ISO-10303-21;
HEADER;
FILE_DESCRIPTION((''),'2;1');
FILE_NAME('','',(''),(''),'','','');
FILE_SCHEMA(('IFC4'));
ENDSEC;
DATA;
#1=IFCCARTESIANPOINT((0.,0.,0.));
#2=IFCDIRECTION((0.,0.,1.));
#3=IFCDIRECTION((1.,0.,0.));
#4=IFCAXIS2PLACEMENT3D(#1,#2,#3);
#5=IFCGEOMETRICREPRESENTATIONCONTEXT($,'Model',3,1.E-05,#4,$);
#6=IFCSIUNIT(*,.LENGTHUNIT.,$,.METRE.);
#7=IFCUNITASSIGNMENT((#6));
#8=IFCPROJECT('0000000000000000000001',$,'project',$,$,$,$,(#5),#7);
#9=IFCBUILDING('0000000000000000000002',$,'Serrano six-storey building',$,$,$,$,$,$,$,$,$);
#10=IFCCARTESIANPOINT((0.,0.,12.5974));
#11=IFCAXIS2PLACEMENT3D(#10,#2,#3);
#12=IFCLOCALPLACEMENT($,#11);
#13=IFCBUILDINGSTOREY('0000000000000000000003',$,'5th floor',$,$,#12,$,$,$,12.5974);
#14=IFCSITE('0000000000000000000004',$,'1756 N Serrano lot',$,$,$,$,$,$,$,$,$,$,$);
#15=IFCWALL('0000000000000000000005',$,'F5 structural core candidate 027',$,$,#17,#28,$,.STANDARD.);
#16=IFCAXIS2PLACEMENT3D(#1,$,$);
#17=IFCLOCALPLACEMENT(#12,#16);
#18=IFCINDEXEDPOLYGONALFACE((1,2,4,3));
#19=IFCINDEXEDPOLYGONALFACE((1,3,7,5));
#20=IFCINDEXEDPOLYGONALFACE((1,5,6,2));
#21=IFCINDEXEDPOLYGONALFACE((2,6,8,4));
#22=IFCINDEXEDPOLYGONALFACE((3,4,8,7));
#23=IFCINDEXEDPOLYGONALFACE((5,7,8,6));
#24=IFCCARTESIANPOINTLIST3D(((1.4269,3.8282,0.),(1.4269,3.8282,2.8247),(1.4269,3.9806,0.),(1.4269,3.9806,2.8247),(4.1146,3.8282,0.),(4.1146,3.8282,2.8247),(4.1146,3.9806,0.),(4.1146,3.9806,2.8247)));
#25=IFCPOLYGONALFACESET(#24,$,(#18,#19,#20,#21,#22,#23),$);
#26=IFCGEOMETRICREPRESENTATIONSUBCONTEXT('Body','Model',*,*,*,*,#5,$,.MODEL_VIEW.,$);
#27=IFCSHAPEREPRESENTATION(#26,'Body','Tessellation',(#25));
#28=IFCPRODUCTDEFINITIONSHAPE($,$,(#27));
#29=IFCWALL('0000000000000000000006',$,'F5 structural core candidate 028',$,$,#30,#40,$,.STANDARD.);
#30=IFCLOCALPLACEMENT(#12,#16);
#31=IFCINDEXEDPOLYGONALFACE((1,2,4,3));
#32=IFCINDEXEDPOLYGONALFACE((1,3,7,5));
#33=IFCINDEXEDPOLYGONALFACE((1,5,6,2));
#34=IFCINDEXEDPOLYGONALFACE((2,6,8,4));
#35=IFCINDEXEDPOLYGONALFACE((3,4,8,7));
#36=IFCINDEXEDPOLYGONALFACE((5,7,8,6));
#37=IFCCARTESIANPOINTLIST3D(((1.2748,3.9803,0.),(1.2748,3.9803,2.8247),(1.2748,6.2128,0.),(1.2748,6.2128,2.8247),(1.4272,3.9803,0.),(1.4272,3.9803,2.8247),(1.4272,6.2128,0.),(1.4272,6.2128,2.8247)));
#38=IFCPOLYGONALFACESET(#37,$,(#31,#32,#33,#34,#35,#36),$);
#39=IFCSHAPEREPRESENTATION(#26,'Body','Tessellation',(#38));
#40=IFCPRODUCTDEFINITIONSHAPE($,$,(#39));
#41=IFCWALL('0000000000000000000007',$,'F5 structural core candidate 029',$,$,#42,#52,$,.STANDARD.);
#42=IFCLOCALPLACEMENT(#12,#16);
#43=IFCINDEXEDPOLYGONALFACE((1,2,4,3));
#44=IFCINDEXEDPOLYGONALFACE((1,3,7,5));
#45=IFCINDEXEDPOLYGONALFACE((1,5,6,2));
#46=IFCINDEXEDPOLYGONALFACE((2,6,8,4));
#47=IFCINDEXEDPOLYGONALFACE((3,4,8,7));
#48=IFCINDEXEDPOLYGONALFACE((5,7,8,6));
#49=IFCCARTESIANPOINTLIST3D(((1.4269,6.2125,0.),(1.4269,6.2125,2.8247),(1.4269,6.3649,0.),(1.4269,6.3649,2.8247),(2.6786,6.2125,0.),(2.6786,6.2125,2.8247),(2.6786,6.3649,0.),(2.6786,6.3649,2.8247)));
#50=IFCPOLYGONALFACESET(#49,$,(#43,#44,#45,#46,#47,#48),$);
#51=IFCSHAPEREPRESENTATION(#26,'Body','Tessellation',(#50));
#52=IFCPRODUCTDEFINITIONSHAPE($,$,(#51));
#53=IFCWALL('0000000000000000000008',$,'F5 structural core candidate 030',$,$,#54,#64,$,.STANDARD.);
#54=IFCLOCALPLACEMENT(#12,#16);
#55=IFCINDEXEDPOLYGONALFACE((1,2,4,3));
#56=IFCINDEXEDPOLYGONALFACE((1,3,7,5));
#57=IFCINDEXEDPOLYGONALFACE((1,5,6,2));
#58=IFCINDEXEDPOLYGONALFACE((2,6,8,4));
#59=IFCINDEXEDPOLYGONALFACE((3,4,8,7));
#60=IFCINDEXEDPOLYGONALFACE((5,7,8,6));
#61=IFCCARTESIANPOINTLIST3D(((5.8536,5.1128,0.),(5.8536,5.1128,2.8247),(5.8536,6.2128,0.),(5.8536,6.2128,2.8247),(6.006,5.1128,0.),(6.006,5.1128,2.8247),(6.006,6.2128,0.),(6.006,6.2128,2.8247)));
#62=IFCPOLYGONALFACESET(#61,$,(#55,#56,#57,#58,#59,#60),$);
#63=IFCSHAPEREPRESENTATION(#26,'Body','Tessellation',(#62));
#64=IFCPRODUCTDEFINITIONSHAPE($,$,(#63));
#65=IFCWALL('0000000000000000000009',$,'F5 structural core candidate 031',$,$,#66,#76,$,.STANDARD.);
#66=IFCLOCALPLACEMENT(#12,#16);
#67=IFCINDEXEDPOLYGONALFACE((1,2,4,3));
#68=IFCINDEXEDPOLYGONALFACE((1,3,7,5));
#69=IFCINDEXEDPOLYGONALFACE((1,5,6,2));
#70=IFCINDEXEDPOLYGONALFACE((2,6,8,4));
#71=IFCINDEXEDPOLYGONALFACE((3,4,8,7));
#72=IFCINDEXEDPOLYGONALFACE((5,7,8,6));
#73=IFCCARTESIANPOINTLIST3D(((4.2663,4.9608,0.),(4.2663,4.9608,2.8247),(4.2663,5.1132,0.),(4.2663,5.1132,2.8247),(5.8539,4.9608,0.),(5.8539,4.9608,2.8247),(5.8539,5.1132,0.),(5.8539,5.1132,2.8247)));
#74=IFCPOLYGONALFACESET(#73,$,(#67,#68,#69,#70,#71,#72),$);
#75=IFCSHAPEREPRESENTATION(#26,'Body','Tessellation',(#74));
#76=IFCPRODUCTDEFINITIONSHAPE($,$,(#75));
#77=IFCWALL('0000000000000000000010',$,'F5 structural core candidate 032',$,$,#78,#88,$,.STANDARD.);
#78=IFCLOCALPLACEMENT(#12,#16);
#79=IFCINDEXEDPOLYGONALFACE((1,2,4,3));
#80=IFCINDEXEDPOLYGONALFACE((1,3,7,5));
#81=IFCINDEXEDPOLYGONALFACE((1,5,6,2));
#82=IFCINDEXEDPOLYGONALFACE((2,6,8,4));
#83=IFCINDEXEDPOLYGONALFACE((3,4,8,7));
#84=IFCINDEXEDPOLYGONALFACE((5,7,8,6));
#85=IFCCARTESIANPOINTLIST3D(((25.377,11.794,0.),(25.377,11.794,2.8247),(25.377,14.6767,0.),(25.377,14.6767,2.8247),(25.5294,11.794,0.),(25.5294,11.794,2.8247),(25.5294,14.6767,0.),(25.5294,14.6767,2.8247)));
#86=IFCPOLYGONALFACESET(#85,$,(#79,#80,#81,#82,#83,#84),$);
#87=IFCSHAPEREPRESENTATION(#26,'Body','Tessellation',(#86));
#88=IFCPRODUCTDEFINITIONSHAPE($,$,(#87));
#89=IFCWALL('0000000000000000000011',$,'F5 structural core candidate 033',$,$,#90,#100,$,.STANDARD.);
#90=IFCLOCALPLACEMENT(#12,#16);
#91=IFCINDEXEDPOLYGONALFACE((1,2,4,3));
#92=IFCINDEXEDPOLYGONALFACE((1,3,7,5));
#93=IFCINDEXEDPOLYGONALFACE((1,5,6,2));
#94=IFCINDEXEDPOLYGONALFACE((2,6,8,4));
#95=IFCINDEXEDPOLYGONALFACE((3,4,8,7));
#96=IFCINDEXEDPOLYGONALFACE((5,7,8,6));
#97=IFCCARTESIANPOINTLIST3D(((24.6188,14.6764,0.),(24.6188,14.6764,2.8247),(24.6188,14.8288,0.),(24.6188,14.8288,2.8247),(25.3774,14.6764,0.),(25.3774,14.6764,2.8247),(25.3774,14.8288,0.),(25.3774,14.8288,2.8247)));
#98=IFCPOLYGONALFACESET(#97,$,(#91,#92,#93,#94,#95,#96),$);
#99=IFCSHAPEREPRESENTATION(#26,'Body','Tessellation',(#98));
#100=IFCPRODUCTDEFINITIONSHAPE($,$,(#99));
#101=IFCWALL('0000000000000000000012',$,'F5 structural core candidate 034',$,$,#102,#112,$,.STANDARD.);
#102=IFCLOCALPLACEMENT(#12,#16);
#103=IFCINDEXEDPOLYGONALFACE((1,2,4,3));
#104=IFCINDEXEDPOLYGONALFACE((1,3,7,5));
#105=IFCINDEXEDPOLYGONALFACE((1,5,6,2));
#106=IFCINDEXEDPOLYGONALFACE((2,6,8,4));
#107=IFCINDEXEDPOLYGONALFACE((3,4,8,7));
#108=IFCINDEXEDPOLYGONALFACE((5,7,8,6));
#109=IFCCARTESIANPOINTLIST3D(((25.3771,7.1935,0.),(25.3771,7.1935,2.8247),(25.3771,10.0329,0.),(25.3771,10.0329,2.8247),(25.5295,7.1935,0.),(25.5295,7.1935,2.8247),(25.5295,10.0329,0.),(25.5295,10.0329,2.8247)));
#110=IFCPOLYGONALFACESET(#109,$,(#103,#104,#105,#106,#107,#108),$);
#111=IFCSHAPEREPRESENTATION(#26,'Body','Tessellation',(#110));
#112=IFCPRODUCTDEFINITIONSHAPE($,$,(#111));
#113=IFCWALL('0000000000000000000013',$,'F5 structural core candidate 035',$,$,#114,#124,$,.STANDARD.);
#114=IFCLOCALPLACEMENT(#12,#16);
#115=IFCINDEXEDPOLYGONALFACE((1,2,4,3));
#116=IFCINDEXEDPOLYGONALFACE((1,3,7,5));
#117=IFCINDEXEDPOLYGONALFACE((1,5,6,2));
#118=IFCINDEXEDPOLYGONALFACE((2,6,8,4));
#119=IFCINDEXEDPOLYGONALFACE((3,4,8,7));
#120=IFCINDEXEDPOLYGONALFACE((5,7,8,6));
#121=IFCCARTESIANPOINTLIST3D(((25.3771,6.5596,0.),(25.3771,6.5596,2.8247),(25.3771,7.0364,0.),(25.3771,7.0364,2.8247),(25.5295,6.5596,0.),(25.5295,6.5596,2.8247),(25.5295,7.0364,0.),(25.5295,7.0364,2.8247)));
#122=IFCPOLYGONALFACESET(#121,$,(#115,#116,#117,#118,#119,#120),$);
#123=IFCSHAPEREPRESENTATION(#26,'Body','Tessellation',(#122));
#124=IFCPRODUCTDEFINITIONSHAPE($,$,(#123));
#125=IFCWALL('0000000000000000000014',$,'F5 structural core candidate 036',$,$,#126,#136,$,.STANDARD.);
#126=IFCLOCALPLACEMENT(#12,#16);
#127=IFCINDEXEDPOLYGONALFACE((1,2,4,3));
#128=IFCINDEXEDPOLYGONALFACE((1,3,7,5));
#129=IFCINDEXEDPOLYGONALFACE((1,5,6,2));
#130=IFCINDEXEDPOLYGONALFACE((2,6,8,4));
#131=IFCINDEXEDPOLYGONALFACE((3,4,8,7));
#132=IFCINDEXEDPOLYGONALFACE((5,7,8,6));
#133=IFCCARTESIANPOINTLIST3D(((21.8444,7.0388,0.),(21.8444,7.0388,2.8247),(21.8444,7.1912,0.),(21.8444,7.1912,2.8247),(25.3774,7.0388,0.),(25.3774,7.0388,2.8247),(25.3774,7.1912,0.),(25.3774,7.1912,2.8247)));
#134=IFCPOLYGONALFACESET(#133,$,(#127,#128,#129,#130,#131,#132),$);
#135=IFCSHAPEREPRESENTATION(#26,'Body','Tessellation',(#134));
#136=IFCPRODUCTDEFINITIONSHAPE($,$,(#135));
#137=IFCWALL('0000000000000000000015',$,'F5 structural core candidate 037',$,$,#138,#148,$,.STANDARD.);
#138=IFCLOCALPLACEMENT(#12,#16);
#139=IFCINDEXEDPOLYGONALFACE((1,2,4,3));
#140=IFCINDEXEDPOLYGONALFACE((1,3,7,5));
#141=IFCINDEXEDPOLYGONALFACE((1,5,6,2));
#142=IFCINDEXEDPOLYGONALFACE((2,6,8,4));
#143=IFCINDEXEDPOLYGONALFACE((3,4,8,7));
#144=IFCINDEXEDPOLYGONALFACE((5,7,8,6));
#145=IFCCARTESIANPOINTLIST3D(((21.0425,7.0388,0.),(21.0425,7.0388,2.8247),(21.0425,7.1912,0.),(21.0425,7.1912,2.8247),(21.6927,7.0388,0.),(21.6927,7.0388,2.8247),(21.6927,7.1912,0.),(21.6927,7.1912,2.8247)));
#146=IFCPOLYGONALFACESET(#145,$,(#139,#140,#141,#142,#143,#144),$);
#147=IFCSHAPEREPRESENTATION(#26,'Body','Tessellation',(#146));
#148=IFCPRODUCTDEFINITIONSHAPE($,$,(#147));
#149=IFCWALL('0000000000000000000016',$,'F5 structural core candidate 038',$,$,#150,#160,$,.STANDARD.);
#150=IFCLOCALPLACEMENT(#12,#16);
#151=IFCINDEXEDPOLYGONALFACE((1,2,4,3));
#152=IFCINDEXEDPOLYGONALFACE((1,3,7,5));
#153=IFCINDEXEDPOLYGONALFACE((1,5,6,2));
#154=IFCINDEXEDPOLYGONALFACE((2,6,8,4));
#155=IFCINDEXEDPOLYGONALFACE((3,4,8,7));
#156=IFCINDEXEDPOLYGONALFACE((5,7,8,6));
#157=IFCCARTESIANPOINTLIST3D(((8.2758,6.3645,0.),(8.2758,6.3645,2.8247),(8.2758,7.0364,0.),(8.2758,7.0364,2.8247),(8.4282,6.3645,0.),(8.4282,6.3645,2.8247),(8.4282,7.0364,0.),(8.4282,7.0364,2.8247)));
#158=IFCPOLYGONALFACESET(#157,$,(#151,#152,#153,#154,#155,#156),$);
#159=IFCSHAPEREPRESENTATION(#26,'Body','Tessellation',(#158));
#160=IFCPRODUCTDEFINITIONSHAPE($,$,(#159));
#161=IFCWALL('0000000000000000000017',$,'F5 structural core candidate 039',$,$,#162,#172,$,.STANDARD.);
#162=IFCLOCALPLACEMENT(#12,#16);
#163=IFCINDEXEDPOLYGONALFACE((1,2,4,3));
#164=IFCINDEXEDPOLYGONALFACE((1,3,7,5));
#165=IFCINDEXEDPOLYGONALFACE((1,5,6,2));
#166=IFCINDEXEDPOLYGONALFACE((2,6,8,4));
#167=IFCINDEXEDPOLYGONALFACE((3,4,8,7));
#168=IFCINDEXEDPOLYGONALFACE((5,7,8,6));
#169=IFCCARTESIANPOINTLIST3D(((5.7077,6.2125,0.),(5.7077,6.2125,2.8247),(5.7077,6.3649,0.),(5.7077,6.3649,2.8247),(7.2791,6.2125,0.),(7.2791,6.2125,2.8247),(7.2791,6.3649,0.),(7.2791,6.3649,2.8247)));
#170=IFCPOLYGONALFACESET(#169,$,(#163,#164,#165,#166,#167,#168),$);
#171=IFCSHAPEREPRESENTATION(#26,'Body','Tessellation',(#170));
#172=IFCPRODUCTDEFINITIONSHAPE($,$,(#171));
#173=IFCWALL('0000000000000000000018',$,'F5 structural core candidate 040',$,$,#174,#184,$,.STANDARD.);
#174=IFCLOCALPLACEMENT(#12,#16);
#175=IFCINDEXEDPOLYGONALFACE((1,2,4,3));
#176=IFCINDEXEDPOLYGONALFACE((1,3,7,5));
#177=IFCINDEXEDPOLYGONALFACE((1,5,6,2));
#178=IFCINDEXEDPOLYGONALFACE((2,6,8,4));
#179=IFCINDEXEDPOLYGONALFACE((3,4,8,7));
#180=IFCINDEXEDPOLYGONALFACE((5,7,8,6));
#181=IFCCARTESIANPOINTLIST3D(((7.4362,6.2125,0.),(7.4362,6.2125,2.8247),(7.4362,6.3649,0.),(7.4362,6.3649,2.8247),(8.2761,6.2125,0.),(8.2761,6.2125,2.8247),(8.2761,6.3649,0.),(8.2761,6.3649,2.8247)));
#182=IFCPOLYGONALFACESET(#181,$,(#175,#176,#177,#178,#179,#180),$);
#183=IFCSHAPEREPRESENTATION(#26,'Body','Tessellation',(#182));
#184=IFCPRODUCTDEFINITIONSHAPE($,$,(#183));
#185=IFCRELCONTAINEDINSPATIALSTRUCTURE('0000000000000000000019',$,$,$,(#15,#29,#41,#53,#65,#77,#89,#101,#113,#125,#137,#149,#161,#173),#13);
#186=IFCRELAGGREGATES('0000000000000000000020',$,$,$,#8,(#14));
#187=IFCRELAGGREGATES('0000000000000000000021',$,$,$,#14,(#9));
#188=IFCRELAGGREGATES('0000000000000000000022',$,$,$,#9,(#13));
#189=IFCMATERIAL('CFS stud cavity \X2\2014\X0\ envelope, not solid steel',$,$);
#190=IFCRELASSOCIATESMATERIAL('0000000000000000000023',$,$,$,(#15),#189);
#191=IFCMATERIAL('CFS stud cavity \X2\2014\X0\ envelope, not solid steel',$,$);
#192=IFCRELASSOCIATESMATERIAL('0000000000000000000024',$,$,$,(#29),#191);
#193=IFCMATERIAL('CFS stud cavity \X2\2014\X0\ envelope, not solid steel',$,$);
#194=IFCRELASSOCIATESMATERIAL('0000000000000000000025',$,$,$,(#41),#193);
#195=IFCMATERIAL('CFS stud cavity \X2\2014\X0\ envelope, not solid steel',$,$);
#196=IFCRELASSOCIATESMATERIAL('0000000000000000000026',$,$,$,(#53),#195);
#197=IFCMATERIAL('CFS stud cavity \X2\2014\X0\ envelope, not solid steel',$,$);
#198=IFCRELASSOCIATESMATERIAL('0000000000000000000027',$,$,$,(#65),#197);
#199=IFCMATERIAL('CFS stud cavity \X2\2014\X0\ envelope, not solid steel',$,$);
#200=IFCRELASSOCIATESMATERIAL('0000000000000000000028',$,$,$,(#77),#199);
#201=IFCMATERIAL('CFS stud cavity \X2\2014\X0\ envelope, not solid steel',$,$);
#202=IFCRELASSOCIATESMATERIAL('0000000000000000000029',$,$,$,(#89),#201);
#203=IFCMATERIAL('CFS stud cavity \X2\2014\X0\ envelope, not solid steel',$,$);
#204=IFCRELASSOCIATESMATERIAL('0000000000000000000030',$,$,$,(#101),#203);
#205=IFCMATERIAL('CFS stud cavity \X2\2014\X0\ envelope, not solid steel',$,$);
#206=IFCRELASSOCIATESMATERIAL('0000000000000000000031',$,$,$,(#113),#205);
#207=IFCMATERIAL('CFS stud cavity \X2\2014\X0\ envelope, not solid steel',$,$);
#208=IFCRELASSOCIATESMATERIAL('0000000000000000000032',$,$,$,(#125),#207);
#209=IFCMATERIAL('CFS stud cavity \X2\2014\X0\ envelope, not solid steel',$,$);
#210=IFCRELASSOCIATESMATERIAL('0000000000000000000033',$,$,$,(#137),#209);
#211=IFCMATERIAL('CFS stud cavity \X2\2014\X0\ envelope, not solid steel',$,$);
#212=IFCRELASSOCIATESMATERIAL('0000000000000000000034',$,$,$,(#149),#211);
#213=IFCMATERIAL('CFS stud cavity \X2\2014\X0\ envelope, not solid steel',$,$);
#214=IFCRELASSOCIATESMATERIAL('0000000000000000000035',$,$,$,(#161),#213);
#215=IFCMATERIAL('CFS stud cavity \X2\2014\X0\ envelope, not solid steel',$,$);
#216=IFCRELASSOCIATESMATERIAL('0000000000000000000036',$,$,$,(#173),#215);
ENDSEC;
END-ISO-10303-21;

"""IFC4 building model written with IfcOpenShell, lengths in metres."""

from ifc_helpers import new_model, si_unit, frame, origin_with_axes, place, context, subcontext, project, spatial, polyline, outline, extrude, material, element, save


model = new_model("IFC4")

# Units and contexts
model_context = context("Model", 3, precision=1e-05, world=origin_with_axes())
body_context = subcontext(model_context, "Body", "Model", "MODEL_VIEW")
ifc_project = project(units=[si_unit("LENGTHUNIT", "METRE")], contexts=[model_context])

# Site, building, storey
site = spatial("IfcSite", under=ifc_project, Name="1756 N Serrano lot")
building = spatial("IfcBuilding", under=site, Name="Serrano six-storey building")
storey_placement = place(None, frame((0.0, 0.0, 12.5974), z_axis=(0.0, 0.0, 1.0), x_axis=(1.0, 0.0, 0.0)))
storey = spatial("IfcBuildingStorey", under=building, at=storey_placement, Name="5th floor", Elevation=12.5974)

# Walls
ifc_material_1 = material(Name="CFS stud cavity — envelope, not solid steel")
wall_1_placement = place(storey_placement, frame((0.0, 0.0, -12.5974), z_axis=(0.0, 0.0, 1.0), x_axis=(1.0, 0.0, 0.0)))
element("IfcWall", 1, at=wall_1_placement, inside=storey, material=ifc_material_1, Name="F5 structural core candidate 027", PredefinedType="STANDARD", context=body_context, shape_type="SweptSolid", body=[
    extrude(outline(polyline([(4.1146, 3.9806), (4.1146, 3.8282), (1.4269, 3.8282), (1.4269, 3.9806), (4.1146, 3.9806)])), frame((0.0, 0.0, 12.5974)), (0.0, 0.0, 1.0), 2.8247),
])
ifc_material_2 = material(Name="CFS stud cavity — envelope, not solid steel")
wall_2_placement = place(storey_placement, frame((0.0, 0.0, -12.5974), z_axis=(0.0, 0.0, 1.0), x_axis=(1.0, 0.0, 0.0)))
element("IfcWall", 2, at=wall_2_placement, inside=storey, material=ifc_material_2, Name="F5 structural core candidate 028", PredefinedType="STANDARD", context=body_context, shape_type="SweptSolid", body=[
    extrude(outline(polyline([(1.4272, 3.9803), (1.2748, 3.9803), (1.2748, 6.2128), (1.4272, 6.2128), (1.4272, 3.9803)])), frame((0.0, 0.0, 12.5974)), (0.0, 0.0, 1.0), 2.8247),
])
ifc_material_3 = material(Name="CFS stud cavity — envelope, not solid steel")
wall_3_placement = place(storey_placement, frame((0.0, 0.0, -12.5974), z_axis=(0.0, 0.0, 1.0), x_axis=(1.0, 0.0, 0.0)))
element("IfcWall", 3, at=wall_3_placement, inside=storey, material=ifc_material_3, Name="F5 structural core candidate 029", PredefinedType="STANDARD", context=body_context, shape_type="SweptSolid", body=[
    extrude(outline(polyline([(2.6786, 6.3649), (2.6786, 6.2125), (1.4269, 6.2125), (1.4269, 6.3649), (2.6786, 6.3649)])), frame((0.0, 0.0, 12.5974)), (0.0, 0.0, 1.0), 2.8247),
])
ifc_material_4 = material(Name="CFS stud cavity — envelope, not solid steel")
wall_4_placement = place(storey_placement, frame((0.0, 0.0, -12.5974), z_axis=(0.0, 0.0, 1.0), x_axis=(1.0, 0.0, 0.0)))
element("IfcWall", 4, at=wall_4_placement, inside=storey, material=ifc_material_4, Name="F5 structural core candidate 030", PredefinedType="STANDARD", context=body_context, shape_type="SweptSolid", body=[
    extrude(outline(polyline([(6.006, 5.1128), (5.8536, 5.1128), (5.8536, 6.2128), (6.006, 6.2128), (6.006, 5.1128)])), frame((0.0, 0.0, 12.5974)), (0.0, 0.0, 1.0), 2.8247),
])
ifc_material_5 = material(Name="CFS stud cavity — envelope, not solid steel")
wall_5_placement = place(storey_placement, frame((0.0, 0.0, -12.5974), z_axis=(0.0, 0.0, 1.0), x_axis=(1.0, 0.0, 0.0)))
element("IfcWall", 5, at=wall_5_placement, inside=storey, material=ifc_material_5, Name="F5 structural core candidate 031", PredefinedType="STANDARD", context=body_context, shape_type="SweptSolid", body=[
    extrude(outline(polyline([(5.8539, 5.1132), (5.8539, 4.9608), (4.2663, 4.9608), (4.2663, 5.1132), (5.8539, 5.1132)])), frame((0.0, 0.0, 12.5974)), (0.0, 0.0, 1.0), 2.8247),
])
ifc_material_6 = material(Name="CFS stud cavity — envelope, not solid steel")
wall_6_placement = place(storey_placement, frame((0.0, 0.0, -12.5974), z_axis=(0.0, 0.0, 1.0), x_axis=(1.0, 0.0, 0.0)))
element("IfcWall", 6, at=wall_6_placement, inside=storey, material=ifc_material_6, Name="F5 structural core candidate 032", PredefinedType="STANDARD", context=body_context, shape_type="SweptSolid", body=[
    extrude(outline(polyline([(25.5294, 11.794), (25.377, 11.794), (25.377, 14.6767), (25.5294, 14.6767), (25.5294, 11.794)])), frame((0.0, 0.0, 12.5974)), (0.0, 0.0, 1.0), 2.8247),
])
ifc_material_7 = material(Name="CFS stud cavity — envelope, not solid steel")
wall_7_placement = place(storey_placement, frame((0.0, 0.0, -12.5974), z_axis=(0.0, 0.0, 1.0), x_axis=(1.0, 0.0, 0.0)))
element("IfcWall", 7, at=wall_7_placement, inside=storey, material=ifc_material_7, Name="F5 structural core candidate 033", PredefinedType="STANDARD", context=body_context, shape_type="SweptSolid", body=[
    extrude(outline(polyline([(25.3774, 14.8288), (25.3774, 14.6764), (24.6188, 14.6764), (24.6188, 14.8288), (25.3774, 14.8288)])), frame((0.0, 0.0, 12.5974)), (0.0, 0.0, 1.0), 2.8247),
])
ifc_material_8 = material(Name="CFS stud cavity — envelope, not solid steel")
wall_8_placement = place(storey_placement, frame((0.0, 0.0, -12.5974), z_axis=(0.0, 0.0, 1.0), x_axis=(1.0, 0.0, 0.0)))
element("IfcWall", 8, at=wall_8_placement, inside=storey, material=ifc_material_8, Name="F5 structural core candidate 034", PredefinedType="STANDARD", context=body_context, shape_type="SweptSolid", body=[
    extrude(outline(polyline([(25.5295, 7.1935), (25.3771, 7.1935), (25.3771, 10.0329), (25.5295, 10.0329), (25.5295, 7.1935)])), frame((0.0, 0.0, 12.5974)), (0.0, 0.0, 1.0), 2.8247),
])
ifc_material_9 = material(Name="CFS stud cavity — envelope, not solid steel")
wall_9_placement = place(storey_placement, frame((0.0, 0.0, -12.5974), z_axis=(0.0, 0.0, 1.0), x_axis=(1.0, 0.0, 0.0)))
element("IfcWall", 9, at=wall_9_placement, inside=storey, material=ifc_material_9, Name="F5 structural core candidate 035", PredefinedType="STANDARD", context=body_context, shape_type="SweptSolid", body=[
    extrude(outline(polyline([(25.5295, 6.5596), (25.3771, 6.5596), (25.3771, 7.0364), (25.5295, 7.0364), (25.5295, 6.5596)])), frame((0.0, 0.0, 12.5974)), (0.0, 0.0, 1.0), 2.8247),
])
ifc_material_10 = material(Name="CFS stud cavity — envelope, not solid steel")
wall_10_placement = place(storey_placement, frame((0.0, 0.0, -12.5974), z_axis=(0.0, 0.0, 1.0), x_axis=(1.0, 0.0, 0.0)))
element("IfcWall", 10, at=wall_10_placement, inside=storey, material=ifc_material_10, Name="F5 structural core candidate 036", PredefinedType="STANDARD", context=body_context, shape_type="SweptSolid", body=[
    extrude(outline(polyline([(25.3774, 7.1912), (25.3774, 7.0388), (21.8444, 7.0388), (21.8444, 7.1912), (25.3774, 7.1912)])), frame((0.0, 0.0, 12.5974)), (0.0, 0.0, 1.0), 2.8247),
])
ifc_material_11 = material(Name="CFS stud cavity — envelope, not solid steel")
wall_11_placement = place(storey_placement, frame((0.0, 0.0, -12.5974), z_axis=(0.0, 0.0, 1.0), x_axis=(1.0, 0.0, 0.0)))
element("IfcWall", 11, at=wall_11_placement, inside=storey, material=ifc_material_11, Name="F5 structural core candidate 037", PredefinedType="STANDARD", context=body_context, shape_type="SweptSolid", body=[
    extrude(outline(polyline([(21.6927, 7.1912), (21.6927, 7.0388), (21.0425, 7.0388), (21.0425, 7.1912), (21.6927, 7.1912)])), frame((0.0, 0.0, 12.5974)), (0.0, 0.0, 1.0), 2.8247),
])
ifc_material_12 = material(Name="CFS stud cavity — envelope, not solid steel")
wall_12_placement = place(storey_placement, frame((0.0, 0.0, -12.5974), z_axis=(0.0, 0.0, 1.0), x_axis=(1.0, 0.0, 0.0)))
element("IfcWall", 12, at=wall_12_placement, inside=storey, material=ifc_material_12, Name="F5 structural core candidate 038", PredefinedType="STANDARD", context=body_context, shape_type="SweptSolid", body=[
    extrude(outline(polyline([(8.4282, 6.3645), (8.2758, 6.3645), (8.2758, 7.0364), (8.4282, 7.0364), (8.4282, 6.3645)])), frame((0.0, 0.0, 12.5974)), (0.0, 0.0, 1.0), 2.8247),
])
ifc_material_13 = material(Name="CFS stud cavity — envelope, not solid steel")
wall_13_placement = place(storey_placement, frame((0.0, 0.0, -12.5974), z_axis=(0.0, 0.0, 1.0), x_axis=(1.0, 0.0, 0.0)))
element("IfcWall", 13, at=wall_13_placement, inside=storey, material=ifc_material_13, Name="F5 structural core candidate 039", PredefinedType="STANDARD", context=body_context, shape_type="SweptSolid", body=[
    extrude(outline(polyline([(7.2791, 6.3649), (7.2791, 6.2125), (5.7077, 6.2125), (5.7077, 6.3649), (7.2791, 6.3649)])), frame((0.0, 0.0, 12.5974)), (0.0, 0.0, 1.0), 2.8247),
])
ifc_material_14 = material(Name="CFS stud cavity — envelope, not solid steel")
wall_14_placement = place(storey_placement, frame((0.0, 0.0, -12.5974), z_axis=(0.0, 0.0, 1.0), x_axis=(1.0, 0.0, 0.0)))
element("IfcWall", 14, at=wall_14_placement, inside=storey, material=ifc_material_14, Name="F5 structural core candidate 040", PredefinedType="STANDARD", context=body_context, shape_type="SweptSolid", body=[
    extrude(outline(polyline([(8.2761, 6.3649), (8.2761, 6.2125), (7.4362, 6.2125), (7.4362, 6.3649), (8.2761, 6.3649)])), frame((0.0, 0.0, 12.5974)), (0.0, 0.0, 1.0), 2.8247),
])

save(model, "model.ifc")
